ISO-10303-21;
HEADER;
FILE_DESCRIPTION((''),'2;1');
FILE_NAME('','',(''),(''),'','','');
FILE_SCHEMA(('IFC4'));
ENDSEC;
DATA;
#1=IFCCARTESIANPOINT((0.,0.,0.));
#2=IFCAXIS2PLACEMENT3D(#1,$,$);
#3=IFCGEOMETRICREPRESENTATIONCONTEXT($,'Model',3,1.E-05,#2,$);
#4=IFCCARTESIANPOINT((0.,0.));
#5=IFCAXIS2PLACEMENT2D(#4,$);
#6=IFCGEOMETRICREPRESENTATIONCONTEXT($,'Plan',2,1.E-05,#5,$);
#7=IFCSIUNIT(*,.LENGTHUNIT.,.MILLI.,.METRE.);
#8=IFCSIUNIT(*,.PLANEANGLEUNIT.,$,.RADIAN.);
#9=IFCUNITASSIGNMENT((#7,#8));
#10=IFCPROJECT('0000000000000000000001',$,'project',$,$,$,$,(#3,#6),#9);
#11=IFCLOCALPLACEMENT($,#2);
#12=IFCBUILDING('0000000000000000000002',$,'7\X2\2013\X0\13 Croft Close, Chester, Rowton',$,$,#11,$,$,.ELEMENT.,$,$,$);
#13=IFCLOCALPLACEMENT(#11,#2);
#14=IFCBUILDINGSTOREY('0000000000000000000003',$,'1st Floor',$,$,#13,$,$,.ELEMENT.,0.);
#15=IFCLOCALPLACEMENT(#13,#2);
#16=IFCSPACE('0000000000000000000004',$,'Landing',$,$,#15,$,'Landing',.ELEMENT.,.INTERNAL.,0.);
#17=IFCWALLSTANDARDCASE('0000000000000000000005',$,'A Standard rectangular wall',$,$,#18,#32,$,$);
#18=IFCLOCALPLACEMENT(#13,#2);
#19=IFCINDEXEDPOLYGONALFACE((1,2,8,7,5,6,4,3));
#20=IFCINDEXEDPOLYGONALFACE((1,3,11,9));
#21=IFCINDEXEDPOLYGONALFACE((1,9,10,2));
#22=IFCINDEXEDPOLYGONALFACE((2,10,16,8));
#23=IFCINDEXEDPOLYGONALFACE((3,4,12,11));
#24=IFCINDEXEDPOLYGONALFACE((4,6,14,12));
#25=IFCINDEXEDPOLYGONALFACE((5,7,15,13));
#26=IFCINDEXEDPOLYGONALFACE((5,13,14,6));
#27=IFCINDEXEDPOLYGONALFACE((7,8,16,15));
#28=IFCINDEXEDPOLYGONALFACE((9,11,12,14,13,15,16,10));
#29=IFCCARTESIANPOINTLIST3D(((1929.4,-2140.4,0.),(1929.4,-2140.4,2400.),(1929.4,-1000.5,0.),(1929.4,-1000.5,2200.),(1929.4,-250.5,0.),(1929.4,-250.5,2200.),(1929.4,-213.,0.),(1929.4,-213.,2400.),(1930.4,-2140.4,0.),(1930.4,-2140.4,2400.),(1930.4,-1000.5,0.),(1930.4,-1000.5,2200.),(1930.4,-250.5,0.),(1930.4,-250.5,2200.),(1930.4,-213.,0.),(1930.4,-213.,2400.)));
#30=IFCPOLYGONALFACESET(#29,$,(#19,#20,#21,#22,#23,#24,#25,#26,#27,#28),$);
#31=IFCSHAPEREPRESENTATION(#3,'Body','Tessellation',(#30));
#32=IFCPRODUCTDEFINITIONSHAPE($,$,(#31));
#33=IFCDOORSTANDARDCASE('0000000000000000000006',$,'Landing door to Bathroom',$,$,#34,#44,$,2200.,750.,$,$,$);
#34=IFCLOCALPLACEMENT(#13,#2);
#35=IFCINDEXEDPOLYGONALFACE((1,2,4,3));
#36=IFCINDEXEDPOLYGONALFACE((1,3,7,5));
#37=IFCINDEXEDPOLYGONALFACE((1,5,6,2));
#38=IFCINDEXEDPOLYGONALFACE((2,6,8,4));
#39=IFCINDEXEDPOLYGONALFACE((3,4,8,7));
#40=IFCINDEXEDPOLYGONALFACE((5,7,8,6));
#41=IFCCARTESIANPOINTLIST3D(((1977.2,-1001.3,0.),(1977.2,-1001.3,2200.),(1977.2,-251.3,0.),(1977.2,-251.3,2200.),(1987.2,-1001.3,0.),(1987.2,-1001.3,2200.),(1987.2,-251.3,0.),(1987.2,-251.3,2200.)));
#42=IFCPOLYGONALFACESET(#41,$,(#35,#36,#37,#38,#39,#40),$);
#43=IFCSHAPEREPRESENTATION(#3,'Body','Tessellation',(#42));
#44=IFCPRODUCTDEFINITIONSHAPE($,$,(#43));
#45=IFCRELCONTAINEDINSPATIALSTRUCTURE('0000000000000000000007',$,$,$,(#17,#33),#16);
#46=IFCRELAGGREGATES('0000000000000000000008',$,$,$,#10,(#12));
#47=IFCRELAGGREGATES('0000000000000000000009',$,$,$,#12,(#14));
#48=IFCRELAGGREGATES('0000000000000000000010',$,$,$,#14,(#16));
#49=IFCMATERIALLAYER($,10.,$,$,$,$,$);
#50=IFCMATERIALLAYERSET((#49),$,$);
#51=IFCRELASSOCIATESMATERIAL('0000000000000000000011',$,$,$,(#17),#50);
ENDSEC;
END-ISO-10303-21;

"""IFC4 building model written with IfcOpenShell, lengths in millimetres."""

from ifc_helpers import new_model, si_unit, frame, origin, origin_2d, place, context, project, spatial, rectangle, extrude, layer, layer_set, layer_usage, element, fill, save


model = new_model("IFC4")

# Units and contexts
model_context = context("Model", 3, precision=1e-05, world=origin())
plan_context = context("Plan", 2, precision=1e-05, world=origin_2d())
ifc_project = project(units=[si_unit("LENGTHUNIT", "METRE", prefix="MILLI"), si_unit("PLANEANGLEUNIT", "RADIAN")], contexts=[model_context, plan_context])

# Building, storey
building_placement = place(None, origin())
building = spatial("IfcBuilding", under=ifc_project, at=building_placement, Name="7–13 Croft Close, Chester, Rowton", CompositionType="ELEMENT")
storey_placement = place(building_placement, origin())
storey = spatial("IfcBuildingStorey", under=building, at=storey_placement, Name="1st Floor", CompositionType="ELEMENT", Elevation=0.0)

# Shared definitions
space_1_placement = place(storey_placement, origin())
space_1 = spatial("IfcSpace", under=storey, at=space_1_placement, Name="Landing", LongName="Landing", CompositionType="ELEMENT", PredefinedType="INTERNAL", ElevationWithFlooring=0.0)

# Wall, opening, door
ifc_layer_1 = layer(None, 10.0)
ifc_layer_set_1 = layer_set([ifc_layer_1])
ifc_layer_usage_1 = layer_usage(ifc_layer_set_1, "AXIS2", "NEGATIVE", 150.0)
wall_1_placement = place(storey_placement, origin())
wall_1 = element("IfcWallStandardCase", 1, at=wall_1_placement, inside=space_1, material=ifc_layer_usage_1, Name="A Standard rectangular wall", context=model_context, shape_type="SweptSolid", body=[
    extrude(rectangle(XDim=1.0, YDim=1927.4, at=origin_2d()), frame((1929.9, -1176.7, 0.0), x_axis=(-1.0, 0.0, 0.0)), (0.0, 0.0, 1.0), 2400.0),
])
opening_1_placement = place(storey_placement, origin())
opening_1 = element("IfcOpeningElement", 2, at=opening_1_placement, cuts=wall_1, context=model_context, shape_type="SweptSolid", body=[
    extrude(rectangle(XDim=10.0, YDim=750.0, at=origin_2d()), frame((1929.9, -625.5, 0.0), x_axis=(-1.0, 0.0, 0.0)), (0.0, 0.0, 1.0), 2200.0),
])
door_1_placement = place(storey_placement, frame((52.3, -0.8, 0.0)))
door_1 = element("IfcDoorStandardCase", 3, at=door_1_placement, inside=space_1, Name="Landing door to Bathroom", OverallHeight=2200.0, OverallWidth=750.0, context=model_context, shape_type="SweptSolid", body=[
    extrude(rectangle(XDim=10.0, YDim=750.0, at=origin_2d()), frame((1929.9, -625.5, 0.0), x_axis=(-1.0, 0.0, 0.0)), (0.0, 0.0, 1.0), 2200.0),
])
fill(opening_1, door_1)

save(model, "model.ifc")
